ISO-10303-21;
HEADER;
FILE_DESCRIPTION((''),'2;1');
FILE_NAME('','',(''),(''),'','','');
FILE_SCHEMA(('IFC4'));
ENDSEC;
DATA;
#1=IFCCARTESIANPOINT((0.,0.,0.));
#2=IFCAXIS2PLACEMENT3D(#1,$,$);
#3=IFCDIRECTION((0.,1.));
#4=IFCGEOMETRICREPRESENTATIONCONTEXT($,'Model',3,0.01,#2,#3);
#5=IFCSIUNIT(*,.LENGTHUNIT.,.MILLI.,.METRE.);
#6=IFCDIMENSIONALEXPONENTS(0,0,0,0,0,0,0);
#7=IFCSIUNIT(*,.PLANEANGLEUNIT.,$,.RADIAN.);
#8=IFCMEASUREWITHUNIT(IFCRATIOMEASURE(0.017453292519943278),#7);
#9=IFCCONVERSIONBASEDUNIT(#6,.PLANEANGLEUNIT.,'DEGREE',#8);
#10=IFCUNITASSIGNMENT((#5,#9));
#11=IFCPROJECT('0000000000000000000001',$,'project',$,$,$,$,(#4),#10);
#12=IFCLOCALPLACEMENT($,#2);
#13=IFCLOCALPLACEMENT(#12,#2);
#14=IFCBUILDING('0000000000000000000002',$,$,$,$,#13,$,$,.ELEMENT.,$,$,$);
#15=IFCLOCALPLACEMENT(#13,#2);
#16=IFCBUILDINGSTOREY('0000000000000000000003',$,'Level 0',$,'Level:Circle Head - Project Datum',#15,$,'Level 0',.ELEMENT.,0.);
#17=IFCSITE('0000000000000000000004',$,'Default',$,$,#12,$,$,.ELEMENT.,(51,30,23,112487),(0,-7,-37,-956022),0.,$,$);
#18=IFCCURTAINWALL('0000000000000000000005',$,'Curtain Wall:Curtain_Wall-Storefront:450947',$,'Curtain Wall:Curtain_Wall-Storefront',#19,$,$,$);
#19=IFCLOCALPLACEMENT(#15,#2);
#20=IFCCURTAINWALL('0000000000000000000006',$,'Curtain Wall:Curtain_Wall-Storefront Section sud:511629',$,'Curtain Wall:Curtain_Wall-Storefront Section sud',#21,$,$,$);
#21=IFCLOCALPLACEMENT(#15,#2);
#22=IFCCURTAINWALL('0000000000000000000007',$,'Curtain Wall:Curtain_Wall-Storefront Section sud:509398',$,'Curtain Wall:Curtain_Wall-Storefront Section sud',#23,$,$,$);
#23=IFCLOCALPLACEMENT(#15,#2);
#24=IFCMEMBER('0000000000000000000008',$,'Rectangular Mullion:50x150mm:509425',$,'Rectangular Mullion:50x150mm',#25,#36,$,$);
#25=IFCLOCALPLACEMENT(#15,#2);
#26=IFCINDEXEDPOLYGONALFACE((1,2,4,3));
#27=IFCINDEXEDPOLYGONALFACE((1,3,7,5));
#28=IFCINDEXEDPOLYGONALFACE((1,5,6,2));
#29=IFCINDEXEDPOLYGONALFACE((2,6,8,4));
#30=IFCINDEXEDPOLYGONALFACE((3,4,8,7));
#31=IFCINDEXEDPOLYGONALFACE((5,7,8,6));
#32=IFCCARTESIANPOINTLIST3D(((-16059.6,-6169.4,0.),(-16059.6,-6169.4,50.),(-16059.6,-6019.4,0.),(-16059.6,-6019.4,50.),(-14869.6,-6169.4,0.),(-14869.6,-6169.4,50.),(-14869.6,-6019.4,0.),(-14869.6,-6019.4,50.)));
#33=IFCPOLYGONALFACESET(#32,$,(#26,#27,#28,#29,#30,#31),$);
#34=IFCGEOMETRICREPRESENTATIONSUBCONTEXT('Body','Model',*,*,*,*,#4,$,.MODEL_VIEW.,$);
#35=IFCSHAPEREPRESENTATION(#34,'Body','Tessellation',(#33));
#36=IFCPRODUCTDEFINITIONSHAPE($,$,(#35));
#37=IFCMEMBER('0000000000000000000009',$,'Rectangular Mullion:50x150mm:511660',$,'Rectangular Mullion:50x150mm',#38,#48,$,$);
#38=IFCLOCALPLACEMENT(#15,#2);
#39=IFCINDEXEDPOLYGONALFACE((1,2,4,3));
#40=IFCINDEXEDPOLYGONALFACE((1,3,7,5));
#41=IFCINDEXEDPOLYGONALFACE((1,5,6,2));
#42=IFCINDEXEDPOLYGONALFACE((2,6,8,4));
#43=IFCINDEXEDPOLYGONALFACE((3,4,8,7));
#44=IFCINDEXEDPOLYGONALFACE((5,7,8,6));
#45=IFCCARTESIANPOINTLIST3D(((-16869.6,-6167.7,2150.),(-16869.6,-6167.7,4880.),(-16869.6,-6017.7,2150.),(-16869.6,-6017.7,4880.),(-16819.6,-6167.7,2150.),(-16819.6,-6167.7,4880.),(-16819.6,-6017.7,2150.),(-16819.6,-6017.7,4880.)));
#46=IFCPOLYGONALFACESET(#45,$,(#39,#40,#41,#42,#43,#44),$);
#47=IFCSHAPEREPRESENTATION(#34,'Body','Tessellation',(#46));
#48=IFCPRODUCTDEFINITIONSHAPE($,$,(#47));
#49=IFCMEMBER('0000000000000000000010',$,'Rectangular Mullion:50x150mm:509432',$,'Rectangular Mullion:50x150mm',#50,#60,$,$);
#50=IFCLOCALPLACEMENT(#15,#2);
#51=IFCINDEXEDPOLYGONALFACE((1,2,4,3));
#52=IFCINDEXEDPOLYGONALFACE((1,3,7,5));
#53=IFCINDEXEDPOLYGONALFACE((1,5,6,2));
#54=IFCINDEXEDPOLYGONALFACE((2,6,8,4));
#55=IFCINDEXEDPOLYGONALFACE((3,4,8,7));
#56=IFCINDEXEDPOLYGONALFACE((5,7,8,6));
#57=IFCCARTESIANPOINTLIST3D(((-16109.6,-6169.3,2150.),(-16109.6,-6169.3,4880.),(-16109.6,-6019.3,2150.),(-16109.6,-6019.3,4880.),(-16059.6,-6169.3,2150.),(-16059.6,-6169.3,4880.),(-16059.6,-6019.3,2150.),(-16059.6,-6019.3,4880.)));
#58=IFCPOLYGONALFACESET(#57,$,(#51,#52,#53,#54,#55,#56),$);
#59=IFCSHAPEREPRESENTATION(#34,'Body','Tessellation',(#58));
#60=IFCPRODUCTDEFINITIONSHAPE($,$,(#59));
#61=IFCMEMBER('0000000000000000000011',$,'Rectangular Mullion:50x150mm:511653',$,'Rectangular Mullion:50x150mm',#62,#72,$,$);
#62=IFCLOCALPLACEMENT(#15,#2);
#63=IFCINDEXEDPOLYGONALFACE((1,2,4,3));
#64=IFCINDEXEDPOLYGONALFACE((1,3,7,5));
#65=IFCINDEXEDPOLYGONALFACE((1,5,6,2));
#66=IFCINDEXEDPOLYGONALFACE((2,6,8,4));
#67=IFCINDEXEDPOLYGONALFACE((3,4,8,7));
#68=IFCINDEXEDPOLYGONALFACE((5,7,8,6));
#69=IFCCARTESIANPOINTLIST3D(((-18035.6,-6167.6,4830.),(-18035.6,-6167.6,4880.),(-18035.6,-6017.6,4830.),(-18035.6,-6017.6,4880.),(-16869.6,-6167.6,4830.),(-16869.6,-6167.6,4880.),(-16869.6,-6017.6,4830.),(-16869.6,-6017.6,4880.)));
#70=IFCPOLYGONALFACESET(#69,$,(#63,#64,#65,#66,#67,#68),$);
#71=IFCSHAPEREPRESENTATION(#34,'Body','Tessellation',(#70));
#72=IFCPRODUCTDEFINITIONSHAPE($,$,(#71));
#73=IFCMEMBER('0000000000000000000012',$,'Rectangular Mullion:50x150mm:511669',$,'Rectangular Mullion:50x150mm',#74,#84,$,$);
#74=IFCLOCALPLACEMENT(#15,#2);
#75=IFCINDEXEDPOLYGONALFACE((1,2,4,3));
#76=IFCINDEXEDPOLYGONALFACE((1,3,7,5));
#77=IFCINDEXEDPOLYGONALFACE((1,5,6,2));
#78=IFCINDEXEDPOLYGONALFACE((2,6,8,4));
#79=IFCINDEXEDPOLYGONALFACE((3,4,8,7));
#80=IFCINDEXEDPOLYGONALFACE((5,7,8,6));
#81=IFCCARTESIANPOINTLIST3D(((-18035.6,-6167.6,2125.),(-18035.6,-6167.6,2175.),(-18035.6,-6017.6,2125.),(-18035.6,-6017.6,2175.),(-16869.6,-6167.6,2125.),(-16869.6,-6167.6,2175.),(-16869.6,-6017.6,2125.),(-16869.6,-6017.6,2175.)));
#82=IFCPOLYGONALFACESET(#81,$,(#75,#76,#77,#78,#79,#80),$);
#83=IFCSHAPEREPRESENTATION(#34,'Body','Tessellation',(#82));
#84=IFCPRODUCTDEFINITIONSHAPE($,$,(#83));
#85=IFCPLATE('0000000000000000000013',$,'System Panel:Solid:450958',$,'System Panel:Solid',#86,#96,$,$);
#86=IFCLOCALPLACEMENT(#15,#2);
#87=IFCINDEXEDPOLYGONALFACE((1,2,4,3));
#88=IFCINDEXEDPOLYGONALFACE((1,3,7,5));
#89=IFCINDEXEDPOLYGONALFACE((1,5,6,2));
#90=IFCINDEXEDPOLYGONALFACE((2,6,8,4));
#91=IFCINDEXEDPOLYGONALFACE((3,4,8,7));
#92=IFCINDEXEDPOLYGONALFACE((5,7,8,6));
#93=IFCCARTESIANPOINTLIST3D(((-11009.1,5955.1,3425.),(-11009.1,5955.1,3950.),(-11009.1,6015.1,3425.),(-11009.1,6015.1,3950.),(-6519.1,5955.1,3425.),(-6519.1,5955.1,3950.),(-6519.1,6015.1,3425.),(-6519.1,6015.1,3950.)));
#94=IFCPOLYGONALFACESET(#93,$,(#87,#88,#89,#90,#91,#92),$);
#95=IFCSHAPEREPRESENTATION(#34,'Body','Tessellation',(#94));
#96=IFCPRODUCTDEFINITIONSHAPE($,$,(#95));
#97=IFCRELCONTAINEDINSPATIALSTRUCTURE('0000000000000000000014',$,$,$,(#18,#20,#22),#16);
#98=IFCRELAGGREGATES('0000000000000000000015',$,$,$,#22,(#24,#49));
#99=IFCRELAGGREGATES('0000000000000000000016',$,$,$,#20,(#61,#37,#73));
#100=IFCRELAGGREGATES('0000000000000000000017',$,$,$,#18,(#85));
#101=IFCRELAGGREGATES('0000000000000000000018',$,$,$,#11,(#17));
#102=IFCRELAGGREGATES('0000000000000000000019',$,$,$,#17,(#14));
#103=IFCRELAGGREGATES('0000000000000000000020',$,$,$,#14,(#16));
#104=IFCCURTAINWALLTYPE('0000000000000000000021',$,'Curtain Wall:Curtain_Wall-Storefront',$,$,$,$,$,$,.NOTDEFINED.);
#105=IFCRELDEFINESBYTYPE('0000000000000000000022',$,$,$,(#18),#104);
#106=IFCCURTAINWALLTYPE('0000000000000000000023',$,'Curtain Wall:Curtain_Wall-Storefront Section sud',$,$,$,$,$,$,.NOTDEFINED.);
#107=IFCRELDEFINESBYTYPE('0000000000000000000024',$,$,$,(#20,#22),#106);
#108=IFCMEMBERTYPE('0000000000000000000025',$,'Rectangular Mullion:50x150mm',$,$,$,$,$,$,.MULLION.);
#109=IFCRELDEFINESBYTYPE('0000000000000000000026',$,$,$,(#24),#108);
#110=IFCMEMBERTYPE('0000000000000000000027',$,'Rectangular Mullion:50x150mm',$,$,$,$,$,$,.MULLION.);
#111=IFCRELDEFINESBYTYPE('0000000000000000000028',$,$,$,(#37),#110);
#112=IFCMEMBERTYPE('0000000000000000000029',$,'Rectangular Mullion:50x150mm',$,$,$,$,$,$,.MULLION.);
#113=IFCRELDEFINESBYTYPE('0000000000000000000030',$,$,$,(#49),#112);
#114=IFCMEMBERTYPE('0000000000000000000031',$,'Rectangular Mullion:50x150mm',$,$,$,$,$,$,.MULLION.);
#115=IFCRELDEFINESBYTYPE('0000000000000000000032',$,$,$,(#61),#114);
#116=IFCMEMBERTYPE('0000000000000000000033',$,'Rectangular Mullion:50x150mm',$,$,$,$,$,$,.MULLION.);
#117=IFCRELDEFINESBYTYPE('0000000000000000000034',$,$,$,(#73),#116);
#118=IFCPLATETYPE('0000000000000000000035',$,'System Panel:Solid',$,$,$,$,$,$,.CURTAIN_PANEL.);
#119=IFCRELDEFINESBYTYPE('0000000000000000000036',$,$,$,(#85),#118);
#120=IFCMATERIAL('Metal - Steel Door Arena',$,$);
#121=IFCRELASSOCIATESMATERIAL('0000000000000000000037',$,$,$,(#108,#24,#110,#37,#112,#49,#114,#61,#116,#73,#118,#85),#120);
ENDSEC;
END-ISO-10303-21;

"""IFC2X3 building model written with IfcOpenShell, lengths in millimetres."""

from ifc_helpers import new_model, entity, si_unit, converted_unit, direction, frame, frame_2d, origin, origin_2d_with_axis, place, context, subcontext, project, spatial, rectangle, extrude, source, transform, mapped, material, type_object, type_shapes, element, aggregate, save


model = new_model("IFC2X3")

# Units and contexts
model_context = context("Model", 3, precision=0.01, world=origin(), true_north=direction((0.0, 1.0)))
body_context = subcontext(model_context, "Body", "Model", "MODEL_VIEW")
ifc_project = project(units=[si_unit("LENGTHUNIT", "METRE", prefix="MILLI"), converted_unit("PLANEANGLEUNIT", "DEGREE", entity("IfcRatioMeasure", 0.017453292519943278), si_unit("PLANEANGLEUNIT", "RADIAN"), dimensions=[0, 0, 0, 0, 0, 0, 0])], contexts=[model_context])

# Site, building, storey
site_placement = place(None, origin())
site = spatial("IfcSite", under=ifc_project, at=site_placement, Name="Default", CompositionType="ELEMENT", RefLatitude=(51, 30, 23, 112487), RefLongitude=(0, -7, -37, -956022), RefElevation=0.0)
building_placement = place(site_placement, origin())
building = spatial("IfcBuilding", under=site, at=building_placement, CompositionType="ELEMENT")
storey_placement = place(building_placement, origin())
storey = spatial("IfcBuildingStorey", under=building, at=storey_placement, Name="Level 0", ObjectType="Level:Circle Head - Project Datum", LongName="Level 0", CompositionType="ELEMENT", Elevation=0.0)

# Curtain walls
curtain_wall_type_1 = type_object("IfcCurtainWallType", Name="Curtain Wall:Curtain_Wall-Storefront", PredefinedType="NOTDEFINED")
curtain_wall_1_placement = place(storey_placement, origin())
curtain_wall_1 = element("IfcCurtainWall", 1, at=curtain_wall_1_placement, inside=storey, type_object=curtain_wall_type_1, Name="Curtain Wall:Curtain_Wall-Storefront:450947", ObjectType="Curtain Wall:Curtain_Wall-Storefront")
ifc_material_1 = material(Name="Metal - Steel Door Arena")
curtain_wall_type_2 = type_object("IfcCurtainWallType", Name="Curtain Wall:Curtain_Wall-Storefront Section sud", PredefinedType="NOTDEFINED")
curtain_wall_2_placement = place(storey_placement, origin())
curtain_wall_2 = element("IfcCurtainWall", 2, at=curtain_wall_2_placement, inside=storey, type_object=curtain_wall_type_2, Name="Curtain Wall:Curtain_Wall-Storefront Section sud:511629", ObjectType="Curtain Wall:Curtain_Wall-Storefront Section sud")
curtain_wall_3_placement = place(storey_placement, origin())
curtain_wall_3 = element("IfcCurtainWall", 3, at=curtain_wall_3_placement, inside=storey, type_object=curtain_wall_type_2, Name="Curtain Wall:Curtain_Wall-Storefront Section sud:509398", ObjectType="Curtain Wall:Curtain_Wall-Storefront Section sud")

# Members
member_type_1 = type_object("IfcMemberType", Name="Rectangular Mullion:50x150mm", PredefinedType="MULLION", material=ifc_material_1)
shared_shape_1 = source(origin(), body_context, "Body", "SweptSolid", [
    extrude(rectangle(XDim=150.0, YDim=50.0, at=origin_2d_with_axis()), frame((-25.0, 0.0, -1190.0), z_axis=(0.0, 0.0, 1.0), x_axis=(0.0, -1.0, 0.0)), (0.0, 0.0, 1.0), 1190.0),
])
type_shapes(member_type_1, [shared_shape_1])
member_1_placement = place(curtain_wall_3_placement, frame((-16059.6, -6094.4, 0.0), z_axis=(-1.0, 0.0, 0.0), x_axis=(0.0, 0.0, -1.0)))
member_1 = element("IfcMember", 4, at=member_1_placement, type_object=member_type_1, material=ifc_material_1, Name="Rectangular Mullion:50x150mm:509425", ObjectType="Rectangular Mullion:50x150mm", context=body_context, shape_type="MappedRepresentation", body=[
    mapped(shared_shape_1, transform((0.0, 0.0, 0.0), scale=1.0)),
])
member_type_2 = type_object("IfcMemberType", Name="Rectangular Mullion:50x150mm", PredefinedType="MULLION", material=ifc_material_1)
shared_shape_2 = source(origin(), body_context, "Body", "SweptSolid", [
    extrude(rectangle(XDim=150.0, YDim=50.0, at=origin_2d_with_axis()), frame((-25.0, 0.0, -2730.0), z_axis=(0.0, 0.0, 1.0), x_axis=(0.0, -1.0, 0.0)), (0.0, 0.0, 1.0), 2730.0),
])
type_shapes(member_type_2, [shared_shape_2])
member_2_placement = place(curtain_wall_2_placement, frame((-16819.6, -6092.7, 2150.0), z_axis=(0.0, 0.0, -1.0), x_axis=(1.0, 0.0, 0.0)))
member_2 = element("IfcMember", 5, at=member_2_placement, type_object=member_type_2, material=ifc_material_1, Name="Rectangular Mullion:50x150mm:511660", ObjectType="Rectangular Mullion:50x150mm", context=body_context, shape_type="MappedRepresentation", body=[
    mapped(shared_shape_2, transform((0.0, 0.0, 0.0), scale=1.0)),
])
member_type_3 = type_object("IfcMemberType", Name="Rectangular Mullion:50x150mm", PredefinedType="MULLION", material=ifc_material_1)
shared_shape_3 = source(origin(), body_context, "Body", "SweptSolid", [
    extrude(rectangle(XDim=150.0, YDim=50.0, at=origin_2d_with_axis()), frame((-25.0, 0.0, -2730.0), z_axis=(0.0, 0.0, 1.0), x_axis=(0.0, -1.0, 0.0)), (0.0, 0.0, 1.0), 2730.0),
])
type_shapes(member_type_3, [shared_shape_3])
member_3_placement = place(curtain_wall_3_placement, frame((-16109.6, -6094.3, 4880.0), z_axis=(0.0, 0.0, 1.0), x_axis=(-1.0, 0.0, 0.0)))
member_3 = element("IfcMember", 6, at=member_3_placement, type_object=member_type_3, material=ifc_material_1, Name="Rectangular Mullion:50x150mm:509432", ObjectType="Rectangular Mullion:50x150mm", context=body_context, shape_type="MappedRepresentation", body=[
    mapped(shared_shape_3, transform((0.0, 0.0, 0.0), scale=1.0)),
])
aggregate(curtain_wall_3, [member_1, member_3])
member_type_4 = type_object("IfcMemberType", Name="Rectangular Mullion:50x150mm", PredefinedType="MULLION", material=ifc_material_1)
shared_shape_4 = source(origin(), body_context, "Body", "SweptSolid", [
    extrude(rectangle(XDim=150.0, YDim=50.0, at=origin_2d_with_axis()), frame((-25.0, 0.0, -1166.0), z_axis=(0.0, 0.0, 1.0), x_axis=(0.0, -1.0, 0.0)), (0.0, 0.0, 1.0), 1166.0),
])
type_shapes(member_type_4, [shared_shape_4])
member_4_placement = place(curtain_wall_2_placement, frame((-16869.6, -6092.6, 4880.0), z_axis=(1.0, 0.0, 0.0), x_axis=(0.0, 0.0, 1.0)))
member_4 = element("IfcMember", 7, at=member_4_placement, type_object=member_type_4, material=ifc_material_1, Name="Rectangular Mullion:50x150mm:511653", ObjectType="Rectangular Mullion:50x150mm", context=body_context, shape_type="MappedRepresentation", body=[
    mapped(shared_shape_4, transform((0.0, 0.0, 0.0), scale=1.0)),
])
member_type_5 = type_object("IfcMemberType", Name="Rectangular Mullion:50x150mm", PredefinedType="MULLION", material=ifc_material_1)
shared_shape_5 = source(origin(), body_context, "Body", "SweptSolid", [
    extrude(rectangle(XDim=150.0, YDim=50.0, at=origin_2d_with_axis()), frame((0.0, 0.0, -1166.0), z_axis=(0.0, 0.0, 1.0), x_axis=(0.0, -1.0, 0.0)), (0.0, 0.0, 1.0), 1166.0),
])
type_shapes(member_type_5, [shared_shape_5])
member_5_placement = place(curtain_wall_2_placement, frame((-16869.6, -6092.6, 2150.0), z_axis=(1.0, 0.0, 0.0), x_axis=(0.0, 0.0, 1.0)))
member_5 = element("IfcMember", 8, at=member_5_placement, type_object=member_type_5, material=ifc_material_1, Name="Rectangular Mullion:50x150mm:511669", ObjectType="Rectangular Mullion:50x150mm", context=body_context, shape_type="MappedRepresentation", body=[
    mapped(shared_shape_5, transform((0.0, 0.0, 0.0), scale=1.0)),
])
aggregate(curtain_wall_2, [member_4, member_2, member_5])

# Plate
plate_type_1 = type_object("IfcPlateType", Name="System Panel:Solid", PredefinedType="CURTAIN_PANEL", material=ifc_material_1)
shared_shape_6 = source(origin(), body_context, "Body", "SweptSolid", [
    extrude(rectangle(XDim=525.0, YDim=4490.0, at=frame_2d((0.0, 0.0), x_axis=(1.0, 0.0))), frame((0.0, 15.0, 262.5), z_axis=(0.0, 1.0, 0.0), x_axis=(0.0, 0.0, 1.0)), (0.0, 0.0, 1.0), 60.0),
])
type_shapes(plate_type_1, [shared_shape_6])
plate_1_placement = place(curtain_wall_1_placement, frame((-8764.1, 6030.1, 3425.0), z_axis=(0.0, 0.0, 1.0), x_axis=(-1.0, 0.0, 0.0)))
plate_1 = element("IfcPlate", 9, at=plate_1_placement, type_object=plate_type_1, material=ifc_material_1, Name="System Panel:Solid:450958", ObjectType="System Panel:Solid", context=body_context, shape_type="MappedRepresentation", body=[
    mapped(shared_shape_6, transform((0.0, 0.0, 0.0), scale=1.0)),
])
aggregate(curtain_wall_1, [plate_1])

save(model, "model.ifc")
